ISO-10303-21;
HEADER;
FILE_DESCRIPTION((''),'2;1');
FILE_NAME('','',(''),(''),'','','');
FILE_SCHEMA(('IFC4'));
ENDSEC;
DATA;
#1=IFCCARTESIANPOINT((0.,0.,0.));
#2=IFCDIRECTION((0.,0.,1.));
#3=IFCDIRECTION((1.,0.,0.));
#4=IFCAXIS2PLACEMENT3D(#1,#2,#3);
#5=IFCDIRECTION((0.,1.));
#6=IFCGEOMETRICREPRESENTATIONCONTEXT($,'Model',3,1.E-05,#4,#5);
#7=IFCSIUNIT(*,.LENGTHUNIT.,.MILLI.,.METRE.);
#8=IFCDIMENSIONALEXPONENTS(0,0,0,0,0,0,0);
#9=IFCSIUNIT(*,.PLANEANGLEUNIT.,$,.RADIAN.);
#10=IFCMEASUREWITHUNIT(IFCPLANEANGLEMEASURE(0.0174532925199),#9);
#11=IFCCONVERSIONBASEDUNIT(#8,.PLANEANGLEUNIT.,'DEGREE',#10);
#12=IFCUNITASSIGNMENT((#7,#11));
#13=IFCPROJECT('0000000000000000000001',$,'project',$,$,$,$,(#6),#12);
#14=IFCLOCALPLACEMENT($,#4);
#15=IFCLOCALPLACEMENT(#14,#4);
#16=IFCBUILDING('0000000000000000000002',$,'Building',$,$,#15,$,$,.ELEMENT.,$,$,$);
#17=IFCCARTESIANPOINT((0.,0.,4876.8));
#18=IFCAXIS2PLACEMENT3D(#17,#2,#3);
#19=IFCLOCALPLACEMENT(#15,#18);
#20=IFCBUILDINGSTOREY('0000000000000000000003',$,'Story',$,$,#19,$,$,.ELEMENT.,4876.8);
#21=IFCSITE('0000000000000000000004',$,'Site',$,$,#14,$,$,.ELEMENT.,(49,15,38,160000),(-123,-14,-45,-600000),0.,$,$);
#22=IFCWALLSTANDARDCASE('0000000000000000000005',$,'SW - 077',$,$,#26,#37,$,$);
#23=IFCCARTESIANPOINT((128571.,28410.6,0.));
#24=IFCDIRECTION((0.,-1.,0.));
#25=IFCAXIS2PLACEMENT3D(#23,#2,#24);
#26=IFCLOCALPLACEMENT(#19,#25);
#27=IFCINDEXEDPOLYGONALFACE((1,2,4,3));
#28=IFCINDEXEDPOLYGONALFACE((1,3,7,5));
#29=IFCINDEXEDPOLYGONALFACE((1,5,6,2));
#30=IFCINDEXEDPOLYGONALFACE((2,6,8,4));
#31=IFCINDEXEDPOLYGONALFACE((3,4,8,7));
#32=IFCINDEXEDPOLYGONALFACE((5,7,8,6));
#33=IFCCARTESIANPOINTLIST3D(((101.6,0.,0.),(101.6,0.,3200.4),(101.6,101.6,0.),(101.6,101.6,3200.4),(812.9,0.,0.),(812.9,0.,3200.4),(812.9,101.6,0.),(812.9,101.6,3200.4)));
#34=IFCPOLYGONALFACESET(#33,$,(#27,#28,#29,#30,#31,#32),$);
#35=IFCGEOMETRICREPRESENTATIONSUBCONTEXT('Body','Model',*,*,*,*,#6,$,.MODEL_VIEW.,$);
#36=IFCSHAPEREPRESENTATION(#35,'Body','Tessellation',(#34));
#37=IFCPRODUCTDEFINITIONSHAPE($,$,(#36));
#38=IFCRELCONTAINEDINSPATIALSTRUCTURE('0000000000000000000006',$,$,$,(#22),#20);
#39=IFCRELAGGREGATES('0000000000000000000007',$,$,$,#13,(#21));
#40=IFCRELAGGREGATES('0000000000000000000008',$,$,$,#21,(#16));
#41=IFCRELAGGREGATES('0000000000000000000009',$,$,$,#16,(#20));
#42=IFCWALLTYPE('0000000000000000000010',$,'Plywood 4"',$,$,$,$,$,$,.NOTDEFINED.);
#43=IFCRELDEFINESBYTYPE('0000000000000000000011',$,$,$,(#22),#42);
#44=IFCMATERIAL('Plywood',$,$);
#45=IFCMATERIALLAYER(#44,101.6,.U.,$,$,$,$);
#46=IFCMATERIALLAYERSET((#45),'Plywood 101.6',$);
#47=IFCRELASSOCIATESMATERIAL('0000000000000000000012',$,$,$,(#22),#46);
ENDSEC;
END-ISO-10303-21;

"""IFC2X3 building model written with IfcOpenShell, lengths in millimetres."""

from ifc_helpers import new_model, entity, si_unit, converted_unit, direction, frame, origin_with_axes, place, context, subcontext, project, spatial, polyline, outline, extrude, material, layer, layer_set, layer_usage, type_object, element, save


model = new_model("IFC2X3")

# Units and contexts
model_context = context("Model", 3, precision=1e-05, world=origin_with_axes(), true_north=direction((0.0, 1.0)))
body_context = subcontext(model_context, "Body", "Model", "MODEL_VIEW")
ifc_project = project(units=[si_unit("LENGTHUNIT", "METRE", prefix="MILLI"), converted_unit("PLANEANGLEUNIT", "DEGREE", entity("IfcPlaneAngleMeasure", 0.0174532925199), si_unit("PLANEANGLEUNIT", "RADIAN"), dimensions=[0, 0, 0, 0, 0, 0, 0])], contexts=[model_context])

# Site, building, storey
site_placement = place(None, origin_with_axes())
site = spatial("IfcSite", under=ifc_project, at=site_placement, Name="Site", CompositionType="ELEMENT", RefLatitude=(49, 15, 38, 160000), RefLongitude=(-123, -14, -45, -600000), RefElevation=0.0)
building_placement = place(site_placement, origin_with_axes())
building = spatial("IfcBuilding", under=site, at=building_placement, Name="Building", CompositionType="ELEMENT")
storey_placement = place(building_placement, frame((0.0, 0.0, 4876.8), z_axis=(0.0, 0.0, 1.0), x_axis=(1.0, 0.0, 0.0)))
storey = spatial("IfcBuildingStorey", under=building, at=storey_placement, Name="Story", CompositionType="ELEMENT", Elevation=4876.8)

# Shared definitions
ifc_material_1 = material(Name="Plywood")

# Shared definitions
ifc_layer_1 = layer(ifc_material_1, 101.6, ventilated="UNKNOWN")
ifc_layer_set_1 = layer_set([ifc_layer_1], Name="Plywood 101.6")
wall_type_1 = type_object("IfcWallType", Name="Plywood 4\"", PredefinedType="NOTDEFINED")

# Wall
ifc_layer_usage_1 = layer_usage(ifc_layer_set_1, "AXIS2", "POSITIVE", 0.0)
wall_1_placement = place(storey_placement, frame((128571.0, 28410.6, 0.0), z_axis=(0.0, 0.0, 1.0), x_axis=(0.0, -1.0, 0.0)))
element("IfcWallStandardCase", 1, at=wall_1_placement, inside=storey, type_object=wall_type_1, material=ifc_layer_usage_1, Name="SW - 077", context=body_context, shape_type="SweptSolid", body=[
    extrude(outline(polyline([(101.6, 0.0), (812.9, 0.0), (812.9, 101.6), (101.6, 101.6), (101.6, 0.0)])), origin_with_axes(), (0.0, 0.0, 1.0), 3200.4),
])

save(model, "model.ifc")
